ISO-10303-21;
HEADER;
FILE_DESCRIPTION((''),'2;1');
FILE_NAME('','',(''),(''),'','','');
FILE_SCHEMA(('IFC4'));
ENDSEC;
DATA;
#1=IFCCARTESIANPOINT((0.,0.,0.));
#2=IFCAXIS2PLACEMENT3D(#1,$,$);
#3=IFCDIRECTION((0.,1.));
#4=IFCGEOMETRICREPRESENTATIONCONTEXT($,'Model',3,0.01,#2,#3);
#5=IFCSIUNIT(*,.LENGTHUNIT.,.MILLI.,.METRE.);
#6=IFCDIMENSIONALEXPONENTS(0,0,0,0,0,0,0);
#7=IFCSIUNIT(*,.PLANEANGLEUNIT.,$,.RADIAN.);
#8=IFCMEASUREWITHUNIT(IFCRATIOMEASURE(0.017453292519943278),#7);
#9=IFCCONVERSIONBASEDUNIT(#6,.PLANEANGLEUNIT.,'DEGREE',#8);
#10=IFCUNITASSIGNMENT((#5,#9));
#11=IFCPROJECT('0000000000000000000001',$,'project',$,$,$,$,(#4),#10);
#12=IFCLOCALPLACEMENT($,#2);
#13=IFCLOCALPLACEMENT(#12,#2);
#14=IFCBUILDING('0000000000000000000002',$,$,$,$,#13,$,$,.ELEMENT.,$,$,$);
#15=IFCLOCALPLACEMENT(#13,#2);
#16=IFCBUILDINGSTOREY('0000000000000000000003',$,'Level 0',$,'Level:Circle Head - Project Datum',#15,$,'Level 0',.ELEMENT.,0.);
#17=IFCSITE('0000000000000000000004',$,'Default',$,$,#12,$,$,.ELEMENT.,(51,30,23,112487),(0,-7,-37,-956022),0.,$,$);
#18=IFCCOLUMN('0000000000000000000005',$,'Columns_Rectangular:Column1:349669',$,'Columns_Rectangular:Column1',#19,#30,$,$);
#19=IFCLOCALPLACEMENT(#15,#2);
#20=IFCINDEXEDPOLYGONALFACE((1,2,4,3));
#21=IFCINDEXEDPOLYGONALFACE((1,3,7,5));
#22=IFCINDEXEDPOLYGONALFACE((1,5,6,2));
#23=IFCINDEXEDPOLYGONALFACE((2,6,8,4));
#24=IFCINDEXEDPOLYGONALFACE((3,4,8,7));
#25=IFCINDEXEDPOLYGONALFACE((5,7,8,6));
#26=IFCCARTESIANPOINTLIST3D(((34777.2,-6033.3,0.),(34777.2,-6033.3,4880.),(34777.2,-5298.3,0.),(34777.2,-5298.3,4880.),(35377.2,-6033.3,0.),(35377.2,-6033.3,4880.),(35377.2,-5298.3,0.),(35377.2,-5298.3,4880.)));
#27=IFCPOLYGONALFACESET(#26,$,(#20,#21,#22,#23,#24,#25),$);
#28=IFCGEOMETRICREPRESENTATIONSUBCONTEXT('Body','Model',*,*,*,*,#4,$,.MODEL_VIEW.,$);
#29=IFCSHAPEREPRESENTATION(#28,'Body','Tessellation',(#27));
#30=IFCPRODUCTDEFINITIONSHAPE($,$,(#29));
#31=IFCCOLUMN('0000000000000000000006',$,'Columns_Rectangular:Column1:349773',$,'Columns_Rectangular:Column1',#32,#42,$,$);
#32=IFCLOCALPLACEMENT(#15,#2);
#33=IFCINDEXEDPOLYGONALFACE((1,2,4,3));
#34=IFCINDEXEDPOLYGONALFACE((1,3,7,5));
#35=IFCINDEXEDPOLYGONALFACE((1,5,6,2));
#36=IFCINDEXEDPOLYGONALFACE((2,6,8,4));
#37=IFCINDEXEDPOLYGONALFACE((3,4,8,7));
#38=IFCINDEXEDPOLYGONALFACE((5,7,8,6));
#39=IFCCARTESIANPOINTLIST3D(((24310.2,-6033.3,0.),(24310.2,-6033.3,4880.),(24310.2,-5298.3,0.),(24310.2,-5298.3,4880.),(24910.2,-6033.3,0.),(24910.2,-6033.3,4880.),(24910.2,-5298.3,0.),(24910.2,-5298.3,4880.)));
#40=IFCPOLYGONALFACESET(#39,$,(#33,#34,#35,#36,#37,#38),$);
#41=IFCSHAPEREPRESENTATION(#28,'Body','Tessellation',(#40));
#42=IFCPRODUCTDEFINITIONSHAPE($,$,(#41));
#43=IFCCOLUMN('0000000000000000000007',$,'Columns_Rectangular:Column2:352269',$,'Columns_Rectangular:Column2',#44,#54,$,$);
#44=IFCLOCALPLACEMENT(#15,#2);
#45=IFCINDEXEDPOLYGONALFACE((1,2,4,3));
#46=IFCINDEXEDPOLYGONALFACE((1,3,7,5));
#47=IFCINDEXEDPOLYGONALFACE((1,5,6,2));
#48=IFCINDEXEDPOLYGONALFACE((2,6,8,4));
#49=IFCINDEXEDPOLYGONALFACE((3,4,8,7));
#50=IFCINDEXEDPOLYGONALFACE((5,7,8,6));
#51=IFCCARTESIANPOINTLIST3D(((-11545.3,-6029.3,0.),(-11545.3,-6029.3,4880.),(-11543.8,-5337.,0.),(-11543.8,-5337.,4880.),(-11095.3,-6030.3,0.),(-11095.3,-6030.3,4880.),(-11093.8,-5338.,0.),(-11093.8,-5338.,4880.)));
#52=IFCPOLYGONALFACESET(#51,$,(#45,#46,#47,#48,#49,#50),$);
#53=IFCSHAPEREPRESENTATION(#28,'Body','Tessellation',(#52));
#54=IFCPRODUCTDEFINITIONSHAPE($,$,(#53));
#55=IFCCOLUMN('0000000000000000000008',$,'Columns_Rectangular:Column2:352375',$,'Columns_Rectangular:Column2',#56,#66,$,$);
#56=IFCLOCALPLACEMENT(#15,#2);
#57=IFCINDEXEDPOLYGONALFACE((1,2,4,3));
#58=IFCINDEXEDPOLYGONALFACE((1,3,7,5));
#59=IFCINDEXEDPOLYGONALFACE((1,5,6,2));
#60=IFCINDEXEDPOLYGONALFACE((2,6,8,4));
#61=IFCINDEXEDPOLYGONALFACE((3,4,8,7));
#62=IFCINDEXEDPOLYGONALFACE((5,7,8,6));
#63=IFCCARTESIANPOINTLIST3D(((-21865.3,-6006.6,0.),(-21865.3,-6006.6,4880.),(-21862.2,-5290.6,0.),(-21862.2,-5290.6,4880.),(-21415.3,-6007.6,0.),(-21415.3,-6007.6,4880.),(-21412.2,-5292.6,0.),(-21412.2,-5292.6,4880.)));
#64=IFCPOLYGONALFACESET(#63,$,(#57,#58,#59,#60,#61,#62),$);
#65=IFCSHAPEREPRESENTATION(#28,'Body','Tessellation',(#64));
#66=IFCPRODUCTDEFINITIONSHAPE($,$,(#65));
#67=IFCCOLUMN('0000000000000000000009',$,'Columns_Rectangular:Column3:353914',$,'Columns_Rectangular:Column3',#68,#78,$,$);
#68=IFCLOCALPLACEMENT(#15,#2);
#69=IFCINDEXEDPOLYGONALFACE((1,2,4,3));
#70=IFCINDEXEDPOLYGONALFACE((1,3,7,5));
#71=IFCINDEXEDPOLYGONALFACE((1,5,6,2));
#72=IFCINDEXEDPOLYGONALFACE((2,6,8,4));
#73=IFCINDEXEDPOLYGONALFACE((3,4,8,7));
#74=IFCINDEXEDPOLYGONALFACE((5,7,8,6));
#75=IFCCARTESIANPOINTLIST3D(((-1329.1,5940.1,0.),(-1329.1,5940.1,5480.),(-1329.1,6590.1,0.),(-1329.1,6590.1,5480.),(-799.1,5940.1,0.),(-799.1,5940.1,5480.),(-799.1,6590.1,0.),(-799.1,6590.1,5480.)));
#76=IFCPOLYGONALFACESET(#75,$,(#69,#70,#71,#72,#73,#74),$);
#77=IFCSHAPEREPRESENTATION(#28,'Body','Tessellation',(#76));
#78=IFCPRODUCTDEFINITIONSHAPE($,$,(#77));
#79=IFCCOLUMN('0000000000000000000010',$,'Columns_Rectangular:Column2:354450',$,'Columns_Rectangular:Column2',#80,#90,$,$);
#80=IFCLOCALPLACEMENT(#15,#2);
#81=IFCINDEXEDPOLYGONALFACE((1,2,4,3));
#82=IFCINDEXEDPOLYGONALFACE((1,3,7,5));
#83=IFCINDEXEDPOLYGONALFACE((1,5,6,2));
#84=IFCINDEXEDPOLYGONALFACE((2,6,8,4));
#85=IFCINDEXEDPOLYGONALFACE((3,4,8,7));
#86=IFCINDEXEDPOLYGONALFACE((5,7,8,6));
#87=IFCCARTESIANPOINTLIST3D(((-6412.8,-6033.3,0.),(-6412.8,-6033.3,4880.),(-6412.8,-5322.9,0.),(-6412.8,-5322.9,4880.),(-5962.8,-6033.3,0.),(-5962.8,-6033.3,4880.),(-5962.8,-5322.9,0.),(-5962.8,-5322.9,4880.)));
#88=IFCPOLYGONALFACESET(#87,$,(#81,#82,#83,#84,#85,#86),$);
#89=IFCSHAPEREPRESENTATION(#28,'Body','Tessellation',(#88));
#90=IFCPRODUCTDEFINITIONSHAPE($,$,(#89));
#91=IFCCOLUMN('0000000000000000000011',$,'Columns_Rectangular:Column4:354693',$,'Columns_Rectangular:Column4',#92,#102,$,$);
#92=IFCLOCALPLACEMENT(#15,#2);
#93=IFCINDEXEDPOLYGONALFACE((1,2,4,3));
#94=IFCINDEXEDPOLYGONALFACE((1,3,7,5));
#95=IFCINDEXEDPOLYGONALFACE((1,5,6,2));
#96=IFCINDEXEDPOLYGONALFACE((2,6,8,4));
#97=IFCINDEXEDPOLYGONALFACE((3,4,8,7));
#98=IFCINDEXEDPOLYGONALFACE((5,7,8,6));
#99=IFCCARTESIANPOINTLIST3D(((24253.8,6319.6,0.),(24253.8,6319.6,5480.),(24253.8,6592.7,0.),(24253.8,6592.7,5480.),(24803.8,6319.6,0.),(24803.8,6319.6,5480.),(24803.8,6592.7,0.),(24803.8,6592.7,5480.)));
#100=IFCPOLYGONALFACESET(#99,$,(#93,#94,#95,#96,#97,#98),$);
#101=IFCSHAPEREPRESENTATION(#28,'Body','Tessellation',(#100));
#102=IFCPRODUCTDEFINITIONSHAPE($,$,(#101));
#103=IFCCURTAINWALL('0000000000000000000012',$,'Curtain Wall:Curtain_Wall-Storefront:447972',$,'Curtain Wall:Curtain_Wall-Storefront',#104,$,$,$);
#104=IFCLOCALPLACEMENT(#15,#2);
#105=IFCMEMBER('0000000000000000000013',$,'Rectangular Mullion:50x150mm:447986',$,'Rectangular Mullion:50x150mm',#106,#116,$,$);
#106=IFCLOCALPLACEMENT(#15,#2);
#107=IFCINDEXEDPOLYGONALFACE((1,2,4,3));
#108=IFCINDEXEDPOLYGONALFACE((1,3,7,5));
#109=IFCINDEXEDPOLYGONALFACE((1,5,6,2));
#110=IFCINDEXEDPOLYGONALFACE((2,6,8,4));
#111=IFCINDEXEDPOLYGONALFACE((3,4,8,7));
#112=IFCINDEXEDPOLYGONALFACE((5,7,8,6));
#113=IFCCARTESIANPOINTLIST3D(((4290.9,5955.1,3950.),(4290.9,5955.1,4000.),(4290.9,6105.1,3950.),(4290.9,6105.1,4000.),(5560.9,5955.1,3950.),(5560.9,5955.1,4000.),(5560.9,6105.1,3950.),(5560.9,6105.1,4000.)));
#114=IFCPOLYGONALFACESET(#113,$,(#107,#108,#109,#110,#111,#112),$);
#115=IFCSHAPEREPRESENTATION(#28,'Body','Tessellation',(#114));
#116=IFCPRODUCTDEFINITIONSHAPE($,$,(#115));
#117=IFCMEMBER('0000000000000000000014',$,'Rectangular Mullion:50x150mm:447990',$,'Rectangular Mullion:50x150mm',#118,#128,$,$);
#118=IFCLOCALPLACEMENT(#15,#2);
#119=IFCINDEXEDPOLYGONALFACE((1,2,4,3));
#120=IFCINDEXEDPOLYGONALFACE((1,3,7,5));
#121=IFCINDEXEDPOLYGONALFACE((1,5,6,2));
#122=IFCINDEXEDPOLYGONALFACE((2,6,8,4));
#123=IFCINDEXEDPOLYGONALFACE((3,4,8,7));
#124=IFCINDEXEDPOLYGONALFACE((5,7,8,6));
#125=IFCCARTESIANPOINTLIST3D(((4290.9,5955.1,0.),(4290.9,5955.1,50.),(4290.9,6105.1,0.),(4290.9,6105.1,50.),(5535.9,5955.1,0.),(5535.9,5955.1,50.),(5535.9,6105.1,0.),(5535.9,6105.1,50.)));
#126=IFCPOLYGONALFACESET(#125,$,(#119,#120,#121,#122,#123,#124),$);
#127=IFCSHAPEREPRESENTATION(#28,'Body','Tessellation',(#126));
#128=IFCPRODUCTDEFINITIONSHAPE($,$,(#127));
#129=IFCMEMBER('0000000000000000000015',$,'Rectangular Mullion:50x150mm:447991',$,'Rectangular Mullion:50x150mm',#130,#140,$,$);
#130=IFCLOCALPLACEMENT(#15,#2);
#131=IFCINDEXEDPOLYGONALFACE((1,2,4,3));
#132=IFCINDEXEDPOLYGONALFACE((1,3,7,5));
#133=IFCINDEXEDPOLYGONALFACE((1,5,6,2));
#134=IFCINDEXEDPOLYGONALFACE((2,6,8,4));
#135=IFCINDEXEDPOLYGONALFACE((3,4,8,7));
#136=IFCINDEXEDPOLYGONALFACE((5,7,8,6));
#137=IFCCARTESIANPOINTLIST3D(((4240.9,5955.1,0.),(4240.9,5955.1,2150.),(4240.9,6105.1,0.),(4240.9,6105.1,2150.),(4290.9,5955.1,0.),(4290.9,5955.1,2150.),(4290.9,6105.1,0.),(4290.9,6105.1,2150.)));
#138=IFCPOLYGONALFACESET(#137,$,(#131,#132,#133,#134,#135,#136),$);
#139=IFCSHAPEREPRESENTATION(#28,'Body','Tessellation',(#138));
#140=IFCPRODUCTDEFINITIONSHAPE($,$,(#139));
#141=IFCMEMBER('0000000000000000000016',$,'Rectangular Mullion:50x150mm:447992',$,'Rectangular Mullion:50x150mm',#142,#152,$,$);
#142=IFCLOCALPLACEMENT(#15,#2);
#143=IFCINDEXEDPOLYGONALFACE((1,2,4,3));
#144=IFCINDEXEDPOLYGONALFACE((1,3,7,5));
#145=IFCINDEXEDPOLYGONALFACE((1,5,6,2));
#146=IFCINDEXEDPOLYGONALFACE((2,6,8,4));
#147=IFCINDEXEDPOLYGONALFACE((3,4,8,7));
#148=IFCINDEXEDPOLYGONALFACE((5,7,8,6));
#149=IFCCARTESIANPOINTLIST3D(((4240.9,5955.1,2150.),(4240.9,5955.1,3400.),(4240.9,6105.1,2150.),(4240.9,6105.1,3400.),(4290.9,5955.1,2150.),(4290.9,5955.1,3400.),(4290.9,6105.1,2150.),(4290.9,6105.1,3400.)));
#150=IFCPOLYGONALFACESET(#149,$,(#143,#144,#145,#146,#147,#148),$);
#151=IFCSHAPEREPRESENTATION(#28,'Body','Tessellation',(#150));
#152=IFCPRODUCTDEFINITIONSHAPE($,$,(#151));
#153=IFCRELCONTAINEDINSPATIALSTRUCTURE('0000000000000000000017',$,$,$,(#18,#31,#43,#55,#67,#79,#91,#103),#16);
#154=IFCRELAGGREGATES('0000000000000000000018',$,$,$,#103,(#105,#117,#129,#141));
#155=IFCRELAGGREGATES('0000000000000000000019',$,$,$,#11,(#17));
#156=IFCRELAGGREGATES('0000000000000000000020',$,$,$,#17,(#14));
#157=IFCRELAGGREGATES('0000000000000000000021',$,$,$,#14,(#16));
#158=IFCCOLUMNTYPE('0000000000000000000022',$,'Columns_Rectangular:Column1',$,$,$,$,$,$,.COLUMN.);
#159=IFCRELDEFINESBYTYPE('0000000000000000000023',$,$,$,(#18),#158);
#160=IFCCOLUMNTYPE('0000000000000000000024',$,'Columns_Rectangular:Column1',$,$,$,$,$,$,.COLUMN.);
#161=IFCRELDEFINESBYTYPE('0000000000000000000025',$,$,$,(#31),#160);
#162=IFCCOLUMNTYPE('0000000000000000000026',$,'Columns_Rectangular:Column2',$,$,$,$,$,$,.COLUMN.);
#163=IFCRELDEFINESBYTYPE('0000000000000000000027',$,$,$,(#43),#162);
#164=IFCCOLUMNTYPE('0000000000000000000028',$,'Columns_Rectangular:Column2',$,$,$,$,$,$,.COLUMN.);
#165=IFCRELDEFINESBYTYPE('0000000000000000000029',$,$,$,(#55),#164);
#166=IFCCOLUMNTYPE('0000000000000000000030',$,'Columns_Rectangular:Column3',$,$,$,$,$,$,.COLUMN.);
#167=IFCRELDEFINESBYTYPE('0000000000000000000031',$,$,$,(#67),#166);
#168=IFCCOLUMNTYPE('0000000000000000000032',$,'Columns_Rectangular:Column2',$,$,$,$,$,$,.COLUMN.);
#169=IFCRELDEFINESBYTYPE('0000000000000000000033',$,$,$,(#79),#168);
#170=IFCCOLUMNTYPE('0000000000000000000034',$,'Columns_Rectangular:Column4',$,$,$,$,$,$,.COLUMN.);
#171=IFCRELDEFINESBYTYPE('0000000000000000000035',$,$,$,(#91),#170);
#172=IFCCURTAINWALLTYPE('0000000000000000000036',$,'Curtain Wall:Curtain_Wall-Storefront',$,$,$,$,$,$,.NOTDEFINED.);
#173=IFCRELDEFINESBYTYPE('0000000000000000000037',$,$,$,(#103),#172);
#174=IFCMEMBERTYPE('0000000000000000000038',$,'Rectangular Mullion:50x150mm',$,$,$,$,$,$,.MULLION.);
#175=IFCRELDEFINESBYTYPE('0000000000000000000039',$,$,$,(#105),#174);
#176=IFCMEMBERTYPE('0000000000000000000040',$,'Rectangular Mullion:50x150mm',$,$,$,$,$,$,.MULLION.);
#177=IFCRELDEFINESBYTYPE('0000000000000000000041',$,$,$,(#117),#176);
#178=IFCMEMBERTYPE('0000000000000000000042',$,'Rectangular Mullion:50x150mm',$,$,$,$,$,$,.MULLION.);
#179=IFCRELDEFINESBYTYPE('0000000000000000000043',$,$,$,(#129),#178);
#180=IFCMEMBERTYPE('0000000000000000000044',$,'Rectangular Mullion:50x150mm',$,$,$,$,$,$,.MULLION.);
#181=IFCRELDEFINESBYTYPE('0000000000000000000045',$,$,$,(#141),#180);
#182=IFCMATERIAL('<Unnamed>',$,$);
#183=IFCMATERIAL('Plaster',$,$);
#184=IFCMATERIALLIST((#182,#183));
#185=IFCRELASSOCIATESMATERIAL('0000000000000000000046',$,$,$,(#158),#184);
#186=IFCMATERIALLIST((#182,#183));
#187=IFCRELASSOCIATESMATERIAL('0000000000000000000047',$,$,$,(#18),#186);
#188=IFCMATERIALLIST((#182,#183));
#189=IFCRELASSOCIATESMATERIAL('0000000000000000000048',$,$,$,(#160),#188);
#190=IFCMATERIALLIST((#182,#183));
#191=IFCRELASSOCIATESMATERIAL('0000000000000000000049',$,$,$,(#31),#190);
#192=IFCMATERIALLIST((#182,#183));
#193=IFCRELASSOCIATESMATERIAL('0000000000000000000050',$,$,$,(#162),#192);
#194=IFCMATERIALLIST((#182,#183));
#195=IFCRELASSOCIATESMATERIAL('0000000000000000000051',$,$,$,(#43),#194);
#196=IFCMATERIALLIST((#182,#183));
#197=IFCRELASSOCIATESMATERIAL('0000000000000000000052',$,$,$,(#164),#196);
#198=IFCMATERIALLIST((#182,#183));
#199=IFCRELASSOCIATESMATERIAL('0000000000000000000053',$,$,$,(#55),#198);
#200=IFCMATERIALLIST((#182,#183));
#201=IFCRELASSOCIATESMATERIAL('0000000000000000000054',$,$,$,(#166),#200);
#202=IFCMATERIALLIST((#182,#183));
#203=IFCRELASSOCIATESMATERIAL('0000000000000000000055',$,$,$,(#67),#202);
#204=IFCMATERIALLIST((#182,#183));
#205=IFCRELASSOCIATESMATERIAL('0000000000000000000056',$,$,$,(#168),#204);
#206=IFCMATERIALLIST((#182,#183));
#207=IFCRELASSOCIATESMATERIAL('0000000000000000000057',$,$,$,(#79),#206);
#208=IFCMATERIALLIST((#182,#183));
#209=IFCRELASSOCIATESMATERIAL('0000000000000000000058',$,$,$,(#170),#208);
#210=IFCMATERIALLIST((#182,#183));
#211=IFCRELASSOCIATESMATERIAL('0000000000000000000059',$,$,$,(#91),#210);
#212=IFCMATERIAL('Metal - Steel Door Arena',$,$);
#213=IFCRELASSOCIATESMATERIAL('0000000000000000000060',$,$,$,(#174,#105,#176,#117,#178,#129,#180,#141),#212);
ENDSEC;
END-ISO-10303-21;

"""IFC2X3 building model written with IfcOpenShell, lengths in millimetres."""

from ifc_helpers import new_model, entity, si_unit, converted_unit, direction, frame, frame_2d, origin, origin_2d_with_axis, place, context, subcontext, project, spatial, polyline, rectangle, outline, extrude, source, transform, mapped, material, material_list, type_object, type_shapes, element, aggregate, save


model = new_model("IFC2X3")

# Units and contexts
model_context = context("Model", 3, precision=0.01, world=origin(), true_north=direction((0.0, 1.0)))
body_context = subcontext(model_context, "Body", "Model", "MODEL_VIEW")
ifc_project = project(units=[si_unit("LENGTHUNIT", "METRE", prefix="MILLI"), converted_unit("PLANEANGLEUNIT", "DEGREE", entity("IfcRatioMeasure", 0.017453292519943278), si_unit("PLANEANGLEUNIT", "RADIAN"), dimensions=[0, 0, 0, 0, 0, 0, 0])], contexts=[model_context])

# Site, building, storey
site_placement = place(None, origin())
site = spatial("IfcSite", under=ifc_project, at=site_placement, Name="Default", CompositionType="ELEMENT", RefLatitude=(51, 30, 23, 112487), RefLongitude=(0, -7, -37, -956022), RefElevation=0.0)
building_placement = place(site_placement, origin())
building = spatial("IfcBuilding", under=site, at=building_placement, CompositionType="ELEMENT")
storey_placement = place(building_placement, origin())
storey = spatial("IfcBuildingStorey", under=building, at=storey_placement, Name="Level 0", ObjectType="Level:Circle Head - Project Datum", LongName="Level 0", CompositionType="ELEMENT", Elevation=0.0)

# Columns
ifc_material_1 = material(Name="<Unnamed>")
ifc_material_2 = material(Name="Plaster")
ifc_material_list_1 = material_list([ifc_material_1, ifc_material_2])
ifc_material_list_2 = material_list([ifc_material_1, ifc_material_2])
column_type_1 = type_object("IfcColumnType", Name="Columns_Rectangular:Column1", PredefinedType="COLUMN", material=ifc_material_list_2)
shared_shape_1 = source(origin(), body_context, "Body", "SweptSolid", [
    extrude(rectangle(XDim=735.0, YDim=600.0, at=origin_2d_with_axis()), frame((35077.2, -5665.8, 0.0), z_axis=(0.0, 0.0, 1.0), x_axis=(0.0, -1.0, 0.0)), (0.0, 0.0, 1.0), 4880.0),
])
type_shapes(column_type_1, [shared_shape_1])
column_1_placement = place(storey_placement, origin())
element("IfcColumn", 1, at=column_1_placement, inside=storey, type_object=column_type_1, material=ifc_material_list_1, Name="Columns_Rectangular:Column1:349669", ObjectType="Columns_Rectangular:Column1", context=body_context, shape_type="MappedRepresentation", body=[
    mapped(shared_shape_1, transform((0.0, 0.0, 0.0), scale=1.0)),
])
ifc_material_list_3 = material_list([ifc_material_1, ifc_material_2])
ifc_material_list_4 = material_list([ifc_material_1, ifc_material_2])
column_type_2 = type_object("IfcColumnType", Name="Columns_Rectangular:Column1", PredefinedType="COLUMN", material=ifc_material_list_4)
shared_shape_2 = source(origin(), body_context, "Body", "SweptSolid", [
    extrude(rectangle(XDim=735.0, YDim=600.0, at=frame_2d((0.0, 0.0), x_axis=(1.0, 0.0))), frame((24610.2, -5665.8, 0.0), z_axis=(0.0, 0.0, 1.0), x_axis=(0.0, -1.0, 0.0)), (0.0, 0.0, 1.0), 4880.0),
])
type_shapes(column_type_2, [shared_shape_2])
column_2_placement = place(storey_placement, origin())
element("IfcColumn", 2, at=column_2_placement, inside=storey, type_object=column_type_2, material=ifc_material_list_3, Name="Columns_Rectangular:Column1:349773", ObjectType="Columns_Rectangular:Column1", context=body_context, shape_type="MappedRepresentation", body=[
    mapped(shared_shape_2, transform((0.0, 0.0, 0.0), scale=1.0)),
])
ifc_material_list_5 = material_list([ifc_material_1, ifc_material_2])
ifc_material_list_6 = material_list([ifc_material_1, ifc_material_2])
column_type_3 = type_object("IfcColumnType", Name="Columns_Rectangular:Column2", PredefinedType="COLUMN", material=ifc_material_list_6)
shared_shape_3 = source(origin(), body_context, "Body", "SweptSolid", [
    extrude(outline(polyline([(-225.0, -346.1), (225.0, -346.1), (225.0, 346.1), (-225.0, 346.1), (-225.0, -346.1)])), frame((-11319.5, -5683.6, 0.0), z_axis=(0.0, 0.0, 1.0), x_axis=(-0.999998, 0.002173, 0.0)), (0.0, 0.0, 1.0), 4880.0),
])
type_shapes(column_type_3, [shared_shape_3])
column_3_placement = place(storey_placement, origin())
element("IfcColumn", 3, at=column_3_placement, inside=storey, type_object=column_type_3, material=ifc_material_list_5, Name="Columns_Rectangular:Column2:352269", ObjectType="Columns_Rectangular:Column2", context=body_context, shape_type="MappedRepresentation", body=[
    mapped(shared_shape_3, transform((0.0, 0.0, 0.0), scale=1.0)),
])
ifc_material_list_7 = material_list([ifc_material_1, ifc_material_2])
ifc_material_list_8 = material_list([ifc_material_1, ifc_material_2])
column_type_4 = type_object("IfcColumnType", Name="Columns_Rectangular:Column2", PredefinedType="COLUMN", material=ifc_material_list_8)
shared_shape_4 = source(origin(), body_context, "Body", "SweptSolid", [
    extrude(outline(polyline([(-225.0, -357.8), (225.0, -357.8), (225.0, 358.3), (-225.0, 357.3), (-225.0, -357.8)])), frame((-21638.7, -5649.3, 0.0), z_axis=(0.0, 0.0, 1.0), x_axis=(-0.99999, 0.004372, 0.0)), (0.0, 0.0, 1.0), 4880.0),
])
type_shapes(column_type_4, [shared_shape_4])
column_4_placement = place(storey_placement, origin())
element("IfcColumn", 4, at=column_4_placement, inside=storey, type_object=column_type_4, material=ifc_material_list_7, Name="Columns_Rectangular:Column2:352375", ObjectType="Columns_Rectangular:Column2", context=body_context, shape_type="MappedRepresentation", body=[
    mapped(shared_shape_4, transform((0.0, 0.0, 0.0), scale=1.0)),
])
ifc_material_list_9 = material_list([ifc_material_1, ifc_material_2])
ifc_material_list_10 = material_list([ifc_material_1, ifc_material_2])
column_type_5 = type_object("IfcColumnType", Name="Columns_Rectangular:Column3", PredefinedType="COLUMN", material=ifc_material_list_10)
shared_shape_5 = source(origin(), body_context, "Body", "SweptSolid", [
    extrude(rectangle(XDim=650.0, YDim=530.0, at=frame_2d((0.0, 0.0), x_axis=(1.0, 0.0))), frame((-1064.1, 6265.1, 0.0), z_axis=(0.0, 0.0, 1.0), x_axis=(0.0, -1.0, 0.0)), (0.0, 0.0, 1.0), 5480.0),
])
type_shapes(column_type_5, [shared_shape_5])
column_5_placement = place(storey_placement, origin())
element("IfcColumn", 5, at=column_5_placement, inside=storey, type_object=column_type_5, material=ifc_material_list_9, Name="Columns_Rectangular:Column3:353914", ObjectType="Columns_Rectangular:Column3", context=body_context, shape_type="MappedRepresentation", body=[
    mapped(shared_shape_5, transform((0.0, 0.0, 0.0), scale=1.0)),
])
ifc_material_list_11 = material_list([ifc_material_1, ifc_material_2])
ifc_material_list_12 = material_list([ifc_material_1, ifc_material_2])
column_type_6 = type_object("IfcColumnType", Name="Columns_Rectangular:Column2", PredefinedType="COLUMN", material=ifc_material_list_12)
shared_shape_6 = source(origin(), body_context, "Body", "SweptSolid", [
    extrude(rectangle(XDim=710.3, YDim=450.0, at=frame_2d((0.0, 0.0), x_axis=(1.0, 0.0))), frame((-6187.8, -5678.1, 0.0), z_axis=(0.0, 0.0, 1.0), x_axis=(0.0, -1.0, 0.0)), (0.0, 0.0, 1.0), 4880.0),
])
type_shapes(column_type_6, [shared_shape_6])
column_6_placement = place(storey_placement, origin())
element("IfcColumn", 6, at=column_6_placement, inside=storey, type_object=column_type_6, material=ifc_material_list_11, Name="Columns_Rectangular:Column2:354450", ObjectType="Columns_Rectangular:Column2", context=body_context, shape_type="MappedRepresentation", body=[
    mapped(shared_shape_6, transform((0.0, 0.0, 0.0), scale=1.0)),
])
ifc_material_list_13 = material_list([ifc_material_1, ifc_material_2])
ifc_material_list_14 = material_list([ifc_material_1, ifc_material_2])
column_type_7 = type_object("IfcColumnType", Name="Columns_Rectangular:Column4", PredefinedType="COLUMN", material=ifc_material_list_14)
shared_shape_7 = source(origin(), body_context, "Body", "SweptSolid", [
    extrude(rectangle(XDim=273.1, YDim=550.0, at=frame_2d((0.0, 0.0), x_axis=(1.0, 0.0))), frame((24528.8, 6456.2, 0.0), z_axis=(0.0, 0.0, 1.0), x_axis=(0.0, -1.0, 0.0)), (0.0, 0.0, 1.0), 5480.0),
])
type_shapes(column_type_7, [shared_shape_7])
column_7_placement = place(storey_placement, origin())
element("IfcColumn", 7, at=column_7_placement, inside=storey, type_object=column_type_7, material=ifc_material_list_13, Name="Columns_Rectangular:Column4:354693", ObjectType="Columns_Rectangular:Column4", context=body_context, shape_type="MappedRepresentation", body=[
    mapped(shared_shape_7, transform((0.0, 0.0, 0.0), scale=1.0)),
])

# Curtain wall, members
curtain_wall_type = type_object("IfcCurtainWallType", Name="Curtain Wall:Curtain_Wall-Storefront", PredefinedType="NOTDEFINED")
curtain_wall_placement = place(storey_placement, origin())
curtain_wall = element("IfcCurtainWall", 8, at=curtain_wall_placement, inside=storey, type_object=curtain_wall_type, Name="Curtain Wall:Curtain_Wall-Storefront:447972", ObjectType="Curtain Wall:Curtain_Wall-Storefront")
ifc_material_3 = material(Name="Metal - Steel Door Arena")
member_type_1 = type_object("IfcMemberType", Name="Rectangular Mullion:50x150mm", PredefinedType="MULLION", material=ifc_material_3)
shared_shape_8 = source(origin(), body_context, "Body", "SweptSolid", [
    extrude(rectangle(XDim=150.0, YDim=50.0, at=origin_2d_with_axis()), frame((-25.0, 0.0, -1270.0), z_axis=(0.0, 0.0, 1.0), x_axis=(0.0, -1.0, 0.0)), (0.0, 0.0, 1.0), 1270.0),
])
type_shapes(member_type_1, [shared_shape_8])
member_1_placement = place(curtain_wall_placement, frame((4290.9, 6030.1, 4000.0), z_axis=(-1.0, 0.0, 0.0), x_axis=(0.0, 0.0, 1.0)))
member_1 = element("IfcMember", 9, at=member_1_placement, type_object=member_type_1, material=ifc_material_3, Name="Rectangular Mullion:50x150mm:447986", ObjectType="Rectangular Mullion:50x150mm", context=body_context, shape_type="MappedRepresentation", body=[
    mapped(shared_shape_8, transform((0.0, 0.0, 0.0), scale=1.0)),
])
member_type_2 = type_object("IfcMemberType", Name="Rectangular Mullion:50x150mm", PredefinedType="MULLION", material=ifc_material_3)
shared_shape_9 = source(origin(), body_context, "Body", "SweptSolid", [
    extrude(rectangle(XDim=150.0, YDim=50.0, at=origin_2d_with_axis()), frame((-25.0, 0.0, -1245.0), z_axis=(0.0, 0.0, 1.0), x_axis=(0.0, -1.0, 0.0)), (0.0, 0.0, 1.0), 1245.0),
])
type_shapes(member_type_2, [shared_shape_9])
member_2_placement = place(curtain_wall_placement, frame((5535.9, 6030.1, 0.0), z_axis=(1.0, 0.0, 0.0), x_axis=(0.0, 0.0, -1.0)))
member_2 = element("IfcMember", 10, at=member_2_placement, type_object=member_type_2, material=ifc_material_3, Name="Rectangular Mullion:50x150mm:447990", ObjectType="Rectangular Mullion:50x150mm", context=body_context, shape_type="MappedRepresentation", body=[
    mapped(shared_shape_9, transform((0.0, 0.0, 0.0), scale=1.0)),
])
member_type_3 = type_object("IfcMemberType", Name="Rectangular Mullion:50x150mm", PredefinedType="MULLION", material=ifc_material_3)
shared_shape_10 = source(origin(), body_context, "Body", "SweptSolid", [
    extrude(rectangle(XDim=150.0, YDim=50.0, at=origin_2d_with_axis()), frame((-25.0, 0.0, -2150.0), z_axis=(0.0, 0.0, 1.0), x_axis=(0.0, -1.0, 0.0)), (0.0, 0.0, 1.0), 2150.0),
])
type_shapes(member_type_3, [shared_shape_10])
member_3_placement = place(curtain_wall_placement, frame((4240.9, 6030.1, 0.0), z_axis=(0.0, 0.0, -1.0), x_axis=(-1.0, 0.0, 0.0)))
member_3 = element("IfcMember", 11, at=member_3_placement, type_object=member_type_3, material=ifc_material_3, Name="Rectangular Mullion:50x150mm:447991", ObjectType="Rectangular Mullion:50x150mm", context=body_context, shape_type="MappedRepresentation", body=[
    mapped(shared_shape_10, transform((0.0, 0.0, 0.0), scale=1.0)),
])
member_type_4 = type_object("IfcMemberType", Name="Rectangular Mullion:50x150mm", PredefinedType="MULLION", material=ifc_material_3)
shared_shape_11 = source(origin(), body_context, "Body", "SweptSolid", [
    extrude(rectangle(XDim=150.0, YDim=50.0, at=origin_2d_with_axis()), frame((-25.0, 0.0, -1250.0), z_axis=(0.0, 0.0, 1.0), x_axis=(0.0, -1.0, 0.0)), (0.0, 0.0, 1.0), 1250.0),
])
type_shapes(member_type_4, [shared_shape_11])
member_4_placement = place(curtain_wall_placement, frame((4240.9, 6030.1, 2150.0), z_axis=(0.0, 0.0, -1.0), x_axis=(-1.0, 0.0, 0.0)))
member_4 = element("IfcMember", 12, at=member_4_placement, type_object=member_type_4, material=ifc_material_3, Name="Rectangular Mullion:50x150mm:447992", ObjectType="Rectangular Mullion:50x150mm", context=body_context, shape_type="MappedRepresentation", body=[
    mapped(shared_shape_11, transform((0.0, 0.0, 0.0), scale=1.0)),
])
aggregate(curtain_wall, [member_1, member_2, member_3, member_4])

save(model, "model.ifc")
